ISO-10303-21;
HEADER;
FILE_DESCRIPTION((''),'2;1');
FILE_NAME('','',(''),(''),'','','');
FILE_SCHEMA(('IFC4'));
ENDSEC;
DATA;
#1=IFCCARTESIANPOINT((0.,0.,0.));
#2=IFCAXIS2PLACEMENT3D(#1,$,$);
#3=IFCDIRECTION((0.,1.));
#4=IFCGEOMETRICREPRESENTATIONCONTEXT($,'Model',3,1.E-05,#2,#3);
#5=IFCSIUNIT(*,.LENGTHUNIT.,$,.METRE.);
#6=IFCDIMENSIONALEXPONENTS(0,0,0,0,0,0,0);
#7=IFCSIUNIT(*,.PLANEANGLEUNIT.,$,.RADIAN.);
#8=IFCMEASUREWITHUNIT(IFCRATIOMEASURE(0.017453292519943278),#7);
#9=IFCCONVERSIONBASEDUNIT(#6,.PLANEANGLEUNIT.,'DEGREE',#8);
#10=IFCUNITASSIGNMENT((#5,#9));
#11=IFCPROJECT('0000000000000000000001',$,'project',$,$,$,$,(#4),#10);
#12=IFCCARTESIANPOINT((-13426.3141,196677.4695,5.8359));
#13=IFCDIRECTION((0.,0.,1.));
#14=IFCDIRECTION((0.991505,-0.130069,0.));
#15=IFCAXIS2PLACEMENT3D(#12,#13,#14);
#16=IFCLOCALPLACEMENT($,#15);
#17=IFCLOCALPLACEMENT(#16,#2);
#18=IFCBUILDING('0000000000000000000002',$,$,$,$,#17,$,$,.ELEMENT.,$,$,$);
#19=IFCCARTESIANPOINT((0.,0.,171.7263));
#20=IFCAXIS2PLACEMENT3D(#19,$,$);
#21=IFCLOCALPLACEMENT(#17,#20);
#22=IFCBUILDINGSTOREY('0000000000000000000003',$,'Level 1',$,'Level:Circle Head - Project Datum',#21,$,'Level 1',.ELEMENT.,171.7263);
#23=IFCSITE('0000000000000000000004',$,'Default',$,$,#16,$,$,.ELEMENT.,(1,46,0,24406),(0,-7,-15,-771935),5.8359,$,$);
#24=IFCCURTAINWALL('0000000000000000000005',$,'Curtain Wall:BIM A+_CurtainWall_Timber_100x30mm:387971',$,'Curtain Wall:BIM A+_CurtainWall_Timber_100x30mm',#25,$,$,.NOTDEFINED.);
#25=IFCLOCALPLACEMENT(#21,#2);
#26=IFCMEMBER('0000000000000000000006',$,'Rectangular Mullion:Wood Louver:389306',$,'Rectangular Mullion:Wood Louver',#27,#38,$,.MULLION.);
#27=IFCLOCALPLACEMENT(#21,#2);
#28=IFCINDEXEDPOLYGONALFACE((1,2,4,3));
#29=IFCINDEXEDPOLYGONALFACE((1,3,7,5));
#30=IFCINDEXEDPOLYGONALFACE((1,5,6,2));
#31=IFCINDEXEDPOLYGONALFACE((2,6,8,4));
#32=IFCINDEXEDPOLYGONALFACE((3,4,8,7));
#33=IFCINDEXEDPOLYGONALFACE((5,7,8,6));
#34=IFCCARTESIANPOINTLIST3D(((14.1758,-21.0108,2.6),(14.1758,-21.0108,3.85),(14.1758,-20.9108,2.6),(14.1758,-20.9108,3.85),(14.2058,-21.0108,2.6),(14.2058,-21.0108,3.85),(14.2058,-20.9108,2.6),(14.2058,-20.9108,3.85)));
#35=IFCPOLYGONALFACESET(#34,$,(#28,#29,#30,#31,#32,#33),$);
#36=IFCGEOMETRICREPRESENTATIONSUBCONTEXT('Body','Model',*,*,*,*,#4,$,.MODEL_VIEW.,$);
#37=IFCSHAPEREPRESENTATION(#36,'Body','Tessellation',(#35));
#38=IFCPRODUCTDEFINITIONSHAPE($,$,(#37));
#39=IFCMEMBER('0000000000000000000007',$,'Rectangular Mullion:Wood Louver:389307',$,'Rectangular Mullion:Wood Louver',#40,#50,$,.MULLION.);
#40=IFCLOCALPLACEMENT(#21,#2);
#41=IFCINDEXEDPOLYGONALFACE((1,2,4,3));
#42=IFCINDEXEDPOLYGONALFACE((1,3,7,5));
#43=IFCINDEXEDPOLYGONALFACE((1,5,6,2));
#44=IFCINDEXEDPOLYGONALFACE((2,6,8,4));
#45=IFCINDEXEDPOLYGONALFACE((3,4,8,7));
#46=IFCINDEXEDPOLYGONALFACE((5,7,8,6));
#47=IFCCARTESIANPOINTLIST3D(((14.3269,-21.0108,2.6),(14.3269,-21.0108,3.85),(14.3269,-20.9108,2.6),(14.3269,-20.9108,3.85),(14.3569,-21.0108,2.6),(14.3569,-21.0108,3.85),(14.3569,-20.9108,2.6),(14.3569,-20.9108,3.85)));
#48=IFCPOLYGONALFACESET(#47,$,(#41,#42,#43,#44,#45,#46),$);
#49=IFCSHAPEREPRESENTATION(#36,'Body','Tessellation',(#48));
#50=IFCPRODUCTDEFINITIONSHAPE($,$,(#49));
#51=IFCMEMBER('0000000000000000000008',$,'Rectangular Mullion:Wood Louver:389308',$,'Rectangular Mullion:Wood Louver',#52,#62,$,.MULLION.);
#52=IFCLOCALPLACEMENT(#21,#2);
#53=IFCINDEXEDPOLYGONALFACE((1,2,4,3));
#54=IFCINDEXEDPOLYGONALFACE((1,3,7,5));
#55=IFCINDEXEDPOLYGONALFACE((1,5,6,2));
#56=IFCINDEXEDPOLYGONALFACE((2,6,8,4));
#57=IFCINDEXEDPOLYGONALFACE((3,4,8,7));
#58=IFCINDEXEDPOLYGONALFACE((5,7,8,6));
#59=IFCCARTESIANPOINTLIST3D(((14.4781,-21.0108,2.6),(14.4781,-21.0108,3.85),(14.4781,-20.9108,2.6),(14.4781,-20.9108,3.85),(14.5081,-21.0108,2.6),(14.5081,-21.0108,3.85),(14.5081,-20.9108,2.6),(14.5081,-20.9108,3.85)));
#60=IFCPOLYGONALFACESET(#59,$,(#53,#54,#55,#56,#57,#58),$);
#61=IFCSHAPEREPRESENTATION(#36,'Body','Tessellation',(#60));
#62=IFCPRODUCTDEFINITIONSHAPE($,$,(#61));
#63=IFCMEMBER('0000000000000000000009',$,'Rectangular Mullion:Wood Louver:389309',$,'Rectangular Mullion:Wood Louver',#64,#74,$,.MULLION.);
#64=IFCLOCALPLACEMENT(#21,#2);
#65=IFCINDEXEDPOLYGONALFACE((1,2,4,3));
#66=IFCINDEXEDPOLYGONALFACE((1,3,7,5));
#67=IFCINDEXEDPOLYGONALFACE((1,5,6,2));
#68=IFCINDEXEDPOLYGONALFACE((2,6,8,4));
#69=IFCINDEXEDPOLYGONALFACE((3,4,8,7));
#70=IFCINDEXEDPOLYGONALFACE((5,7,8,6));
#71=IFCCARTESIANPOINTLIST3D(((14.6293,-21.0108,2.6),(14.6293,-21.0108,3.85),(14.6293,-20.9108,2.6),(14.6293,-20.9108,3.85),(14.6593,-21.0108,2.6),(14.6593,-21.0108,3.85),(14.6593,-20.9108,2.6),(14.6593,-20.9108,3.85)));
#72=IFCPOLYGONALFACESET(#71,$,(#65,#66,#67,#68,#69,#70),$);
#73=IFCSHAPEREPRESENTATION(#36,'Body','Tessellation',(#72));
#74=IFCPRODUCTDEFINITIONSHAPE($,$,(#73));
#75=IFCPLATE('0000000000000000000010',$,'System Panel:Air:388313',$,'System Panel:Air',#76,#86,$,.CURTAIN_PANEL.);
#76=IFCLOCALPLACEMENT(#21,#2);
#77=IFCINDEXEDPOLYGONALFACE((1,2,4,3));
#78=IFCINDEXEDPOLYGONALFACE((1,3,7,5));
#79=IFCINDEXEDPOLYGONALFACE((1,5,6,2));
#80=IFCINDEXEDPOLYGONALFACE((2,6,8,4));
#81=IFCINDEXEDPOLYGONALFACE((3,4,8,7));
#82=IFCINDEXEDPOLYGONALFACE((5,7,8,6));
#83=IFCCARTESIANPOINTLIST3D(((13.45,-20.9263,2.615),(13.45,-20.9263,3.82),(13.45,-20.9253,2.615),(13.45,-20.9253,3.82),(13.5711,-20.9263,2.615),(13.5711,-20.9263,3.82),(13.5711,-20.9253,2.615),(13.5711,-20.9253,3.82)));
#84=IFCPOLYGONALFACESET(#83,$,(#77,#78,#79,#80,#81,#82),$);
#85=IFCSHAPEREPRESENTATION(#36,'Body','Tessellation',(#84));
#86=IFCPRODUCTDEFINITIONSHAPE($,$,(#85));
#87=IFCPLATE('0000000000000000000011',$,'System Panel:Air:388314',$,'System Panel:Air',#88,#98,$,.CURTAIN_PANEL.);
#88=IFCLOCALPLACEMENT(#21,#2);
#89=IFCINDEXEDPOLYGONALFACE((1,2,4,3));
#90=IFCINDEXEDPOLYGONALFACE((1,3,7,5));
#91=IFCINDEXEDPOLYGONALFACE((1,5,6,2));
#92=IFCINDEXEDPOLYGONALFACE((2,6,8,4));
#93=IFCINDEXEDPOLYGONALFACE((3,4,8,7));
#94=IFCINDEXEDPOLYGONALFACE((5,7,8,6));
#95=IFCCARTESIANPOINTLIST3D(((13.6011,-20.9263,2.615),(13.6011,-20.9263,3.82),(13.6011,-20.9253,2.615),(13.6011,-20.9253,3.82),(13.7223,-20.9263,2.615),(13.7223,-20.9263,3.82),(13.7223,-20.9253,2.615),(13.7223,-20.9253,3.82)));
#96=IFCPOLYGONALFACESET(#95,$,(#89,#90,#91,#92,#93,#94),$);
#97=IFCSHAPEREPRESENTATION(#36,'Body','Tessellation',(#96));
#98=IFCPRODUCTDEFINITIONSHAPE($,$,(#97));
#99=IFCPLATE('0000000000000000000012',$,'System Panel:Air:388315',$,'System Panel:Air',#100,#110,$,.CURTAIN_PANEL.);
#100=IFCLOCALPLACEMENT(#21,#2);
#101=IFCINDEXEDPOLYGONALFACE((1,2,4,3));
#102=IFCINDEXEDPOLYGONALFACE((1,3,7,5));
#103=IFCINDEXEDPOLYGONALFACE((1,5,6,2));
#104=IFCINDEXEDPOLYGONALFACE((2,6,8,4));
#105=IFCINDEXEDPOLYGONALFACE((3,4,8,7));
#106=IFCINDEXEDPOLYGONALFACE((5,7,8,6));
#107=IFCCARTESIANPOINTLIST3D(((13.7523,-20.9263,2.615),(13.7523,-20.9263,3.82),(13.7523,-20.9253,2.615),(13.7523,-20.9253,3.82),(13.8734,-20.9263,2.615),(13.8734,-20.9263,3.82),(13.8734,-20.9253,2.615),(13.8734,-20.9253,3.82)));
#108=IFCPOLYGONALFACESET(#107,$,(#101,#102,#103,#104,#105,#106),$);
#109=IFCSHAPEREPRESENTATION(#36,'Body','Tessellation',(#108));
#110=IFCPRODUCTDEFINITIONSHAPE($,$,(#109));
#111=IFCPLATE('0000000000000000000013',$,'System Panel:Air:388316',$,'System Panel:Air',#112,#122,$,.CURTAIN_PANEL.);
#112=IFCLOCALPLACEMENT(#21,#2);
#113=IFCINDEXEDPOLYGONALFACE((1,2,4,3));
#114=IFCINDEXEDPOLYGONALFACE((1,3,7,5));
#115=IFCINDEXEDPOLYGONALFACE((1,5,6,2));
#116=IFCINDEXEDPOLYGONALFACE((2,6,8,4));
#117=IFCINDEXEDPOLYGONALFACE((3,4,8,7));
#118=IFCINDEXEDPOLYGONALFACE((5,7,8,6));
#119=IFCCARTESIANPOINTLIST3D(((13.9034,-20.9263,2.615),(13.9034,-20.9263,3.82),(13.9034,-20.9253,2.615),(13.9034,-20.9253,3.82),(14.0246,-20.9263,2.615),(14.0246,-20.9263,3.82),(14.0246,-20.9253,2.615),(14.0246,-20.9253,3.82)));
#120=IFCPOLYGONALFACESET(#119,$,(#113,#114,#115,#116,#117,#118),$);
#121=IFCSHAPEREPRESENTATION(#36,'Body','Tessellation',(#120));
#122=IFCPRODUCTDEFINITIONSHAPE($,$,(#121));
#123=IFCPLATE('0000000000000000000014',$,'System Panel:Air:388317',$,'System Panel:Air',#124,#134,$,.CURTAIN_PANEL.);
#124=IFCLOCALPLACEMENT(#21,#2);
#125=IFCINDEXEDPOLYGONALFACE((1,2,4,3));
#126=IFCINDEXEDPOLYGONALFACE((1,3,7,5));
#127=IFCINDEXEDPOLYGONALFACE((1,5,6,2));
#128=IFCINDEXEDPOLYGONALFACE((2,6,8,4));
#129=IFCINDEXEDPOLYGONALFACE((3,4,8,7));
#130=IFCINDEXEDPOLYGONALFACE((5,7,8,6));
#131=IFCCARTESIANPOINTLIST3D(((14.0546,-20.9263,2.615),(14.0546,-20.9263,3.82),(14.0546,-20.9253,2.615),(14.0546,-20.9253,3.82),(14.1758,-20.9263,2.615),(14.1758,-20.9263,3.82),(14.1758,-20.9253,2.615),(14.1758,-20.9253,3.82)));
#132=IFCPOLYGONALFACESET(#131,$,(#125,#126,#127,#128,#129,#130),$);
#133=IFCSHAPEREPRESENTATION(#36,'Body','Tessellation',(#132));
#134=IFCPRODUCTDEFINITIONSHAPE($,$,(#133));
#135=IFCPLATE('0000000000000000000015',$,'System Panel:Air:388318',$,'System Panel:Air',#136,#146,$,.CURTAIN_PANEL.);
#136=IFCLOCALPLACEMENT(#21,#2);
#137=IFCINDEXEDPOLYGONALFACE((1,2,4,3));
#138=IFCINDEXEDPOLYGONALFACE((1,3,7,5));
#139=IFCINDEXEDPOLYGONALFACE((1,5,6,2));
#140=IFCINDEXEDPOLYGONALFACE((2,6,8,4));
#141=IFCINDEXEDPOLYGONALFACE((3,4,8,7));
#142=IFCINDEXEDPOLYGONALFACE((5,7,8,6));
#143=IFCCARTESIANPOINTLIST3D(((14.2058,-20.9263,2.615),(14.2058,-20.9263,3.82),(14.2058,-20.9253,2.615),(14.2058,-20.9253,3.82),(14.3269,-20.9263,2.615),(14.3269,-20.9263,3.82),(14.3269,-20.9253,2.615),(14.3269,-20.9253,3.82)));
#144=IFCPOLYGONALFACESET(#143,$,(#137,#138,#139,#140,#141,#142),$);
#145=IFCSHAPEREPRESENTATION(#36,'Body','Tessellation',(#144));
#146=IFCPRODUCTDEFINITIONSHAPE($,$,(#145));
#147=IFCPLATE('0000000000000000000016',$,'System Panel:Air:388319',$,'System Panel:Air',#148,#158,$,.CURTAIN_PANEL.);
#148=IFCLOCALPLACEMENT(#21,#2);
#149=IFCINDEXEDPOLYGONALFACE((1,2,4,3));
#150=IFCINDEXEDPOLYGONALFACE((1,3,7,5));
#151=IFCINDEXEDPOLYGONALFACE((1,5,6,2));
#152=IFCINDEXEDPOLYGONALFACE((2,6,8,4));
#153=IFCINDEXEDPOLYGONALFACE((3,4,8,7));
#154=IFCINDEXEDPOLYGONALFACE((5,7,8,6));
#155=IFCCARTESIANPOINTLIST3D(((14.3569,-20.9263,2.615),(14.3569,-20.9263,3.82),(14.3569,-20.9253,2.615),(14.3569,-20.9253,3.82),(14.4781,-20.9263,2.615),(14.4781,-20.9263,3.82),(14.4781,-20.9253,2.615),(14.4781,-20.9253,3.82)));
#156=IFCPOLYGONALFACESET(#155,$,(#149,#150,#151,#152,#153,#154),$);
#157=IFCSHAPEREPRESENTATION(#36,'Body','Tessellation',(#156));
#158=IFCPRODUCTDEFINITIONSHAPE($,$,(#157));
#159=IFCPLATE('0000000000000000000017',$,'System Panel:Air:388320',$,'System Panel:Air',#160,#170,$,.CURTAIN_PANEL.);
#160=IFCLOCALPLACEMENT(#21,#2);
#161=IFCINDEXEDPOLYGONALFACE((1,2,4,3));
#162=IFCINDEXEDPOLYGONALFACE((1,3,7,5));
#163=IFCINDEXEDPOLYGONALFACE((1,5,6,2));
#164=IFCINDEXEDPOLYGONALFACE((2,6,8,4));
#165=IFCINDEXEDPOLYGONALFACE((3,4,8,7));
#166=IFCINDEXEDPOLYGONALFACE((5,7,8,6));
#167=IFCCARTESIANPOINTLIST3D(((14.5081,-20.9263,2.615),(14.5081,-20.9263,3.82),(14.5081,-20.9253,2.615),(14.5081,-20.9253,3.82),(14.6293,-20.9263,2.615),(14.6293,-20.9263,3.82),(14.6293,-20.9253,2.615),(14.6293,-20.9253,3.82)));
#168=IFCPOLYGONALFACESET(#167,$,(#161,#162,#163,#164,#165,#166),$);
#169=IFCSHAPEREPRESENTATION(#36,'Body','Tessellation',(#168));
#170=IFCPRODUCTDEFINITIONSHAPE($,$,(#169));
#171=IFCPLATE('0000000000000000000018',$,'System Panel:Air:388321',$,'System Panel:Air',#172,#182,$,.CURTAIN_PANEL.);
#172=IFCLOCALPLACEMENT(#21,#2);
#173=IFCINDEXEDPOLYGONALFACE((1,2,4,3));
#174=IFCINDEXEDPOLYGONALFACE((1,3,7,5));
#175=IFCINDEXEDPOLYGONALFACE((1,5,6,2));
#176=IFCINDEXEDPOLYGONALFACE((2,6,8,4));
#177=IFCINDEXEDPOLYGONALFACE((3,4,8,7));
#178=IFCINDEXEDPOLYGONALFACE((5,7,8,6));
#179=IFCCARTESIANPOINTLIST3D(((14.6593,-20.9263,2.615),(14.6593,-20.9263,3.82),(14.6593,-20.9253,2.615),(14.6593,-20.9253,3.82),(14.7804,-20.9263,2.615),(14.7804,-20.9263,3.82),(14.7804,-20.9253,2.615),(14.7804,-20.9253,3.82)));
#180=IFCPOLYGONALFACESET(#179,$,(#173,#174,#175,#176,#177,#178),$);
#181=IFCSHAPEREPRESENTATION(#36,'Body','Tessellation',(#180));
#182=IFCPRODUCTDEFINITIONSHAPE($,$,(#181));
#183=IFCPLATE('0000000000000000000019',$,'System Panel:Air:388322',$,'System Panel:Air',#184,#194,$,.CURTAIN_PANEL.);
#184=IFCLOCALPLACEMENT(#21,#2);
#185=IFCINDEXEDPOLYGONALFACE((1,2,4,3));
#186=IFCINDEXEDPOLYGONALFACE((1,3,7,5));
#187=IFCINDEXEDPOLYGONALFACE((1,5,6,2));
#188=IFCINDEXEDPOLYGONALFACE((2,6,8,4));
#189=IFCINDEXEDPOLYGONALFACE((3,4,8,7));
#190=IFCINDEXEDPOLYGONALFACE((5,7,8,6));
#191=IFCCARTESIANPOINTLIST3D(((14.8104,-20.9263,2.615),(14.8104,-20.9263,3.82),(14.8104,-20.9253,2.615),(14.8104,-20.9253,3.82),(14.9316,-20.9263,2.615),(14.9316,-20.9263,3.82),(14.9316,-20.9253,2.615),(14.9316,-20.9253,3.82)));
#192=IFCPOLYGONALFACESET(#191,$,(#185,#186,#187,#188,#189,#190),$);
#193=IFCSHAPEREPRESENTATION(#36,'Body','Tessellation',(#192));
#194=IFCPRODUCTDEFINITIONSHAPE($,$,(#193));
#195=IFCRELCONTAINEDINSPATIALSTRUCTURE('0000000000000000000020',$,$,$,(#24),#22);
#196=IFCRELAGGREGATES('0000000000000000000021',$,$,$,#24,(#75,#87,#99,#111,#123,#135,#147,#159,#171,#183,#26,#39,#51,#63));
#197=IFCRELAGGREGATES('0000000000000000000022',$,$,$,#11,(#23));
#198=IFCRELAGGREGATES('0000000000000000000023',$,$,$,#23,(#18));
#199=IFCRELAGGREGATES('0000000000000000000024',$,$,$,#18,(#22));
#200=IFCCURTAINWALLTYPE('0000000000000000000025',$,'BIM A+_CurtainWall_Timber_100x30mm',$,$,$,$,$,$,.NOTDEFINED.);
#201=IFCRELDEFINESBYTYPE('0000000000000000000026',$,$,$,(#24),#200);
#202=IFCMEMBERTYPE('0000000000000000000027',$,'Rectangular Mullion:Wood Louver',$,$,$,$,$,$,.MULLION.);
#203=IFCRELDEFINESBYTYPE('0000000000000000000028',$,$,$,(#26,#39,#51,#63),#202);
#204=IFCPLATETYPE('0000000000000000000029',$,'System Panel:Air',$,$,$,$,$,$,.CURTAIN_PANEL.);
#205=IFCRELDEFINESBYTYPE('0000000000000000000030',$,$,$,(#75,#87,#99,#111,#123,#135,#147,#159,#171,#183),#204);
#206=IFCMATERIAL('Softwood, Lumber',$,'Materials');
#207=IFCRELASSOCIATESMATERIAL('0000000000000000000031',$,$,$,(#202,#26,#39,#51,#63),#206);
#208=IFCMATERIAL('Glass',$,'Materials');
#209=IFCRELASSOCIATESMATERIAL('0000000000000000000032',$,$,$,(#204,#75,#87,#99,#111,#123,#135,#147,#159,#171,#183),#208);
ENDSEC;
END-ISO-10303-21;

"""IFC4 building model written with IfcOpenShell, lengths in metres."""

from ifc_helpers import new_model, entity, si_unit, converted_unit, direction, frame, origin, place, context, subcontext, project, spatial, indexed_curve, outline, extrude, source, transform, mapped, material, type_object, type_shapes, element, aggregate, save


model = new_model("IFC4")

# Units and contexts
model_context = context("Model", 3, precision=1e-05, world=origin(), true_north=direction((0.0, 1.0)))
body_context = subcontext(model_context, "Body", "Model", "MODEL_VIEW")
ifc_project = project(units=[si_unit("LENGTHUNIT", "METRE"), converted_unit("PLANEANGLEUNIT", "DEGREE", entity("IfcRatioMeasure", 0.017453292519943278), si_unit("PLANEANGLEUNIT", "RADIAN"), dimensions=[0, 0, 0, 0, 0, 0, 0])], contexts=[model_context])

# Site, building, storey
site_placement = place(None, frame((-13426.3141, 196677.4695, 5.8359), z_axis=(0.0, 0.0, 1.0), x_axis=(0.991505, -0.130069, 0.0)))
site = spatial("IfcSite", under=ifc_project, at=site_placement, Name="Default", CompositionType="ELEMENT", RefLatitude=(1, 46, 0, 24406), RefLongitude=(0, -7, -15, -771935), RefElevation=5.8359)
building_placement = place(site_placement, origin())
building = spatial("IfcBuilding", under=site, at=building_placement, CompositionType="ELEMENT")
storey_placement = place(building_placement, frame((0.0, 0.0, 171.7263)))
storey = spatial("IfcBuildingStorey", under=building, at=storey_placement, Name="Level 1", ObjectType="Level:Circle Head - Project Datum", LongName="Level 1", CompositionType="ELEMENT", Elevation=171.7263)

# Curtain wall, members, plates
curtain_wall_type = type_object("IfcCurtainWallType", Name="BIM A+_CurtainWall_Timber_100x30mm", PredefinedType="NOTDEFINED")
curtain_wall_placement = place(storey_placement, frame((0.0, 0.0, -171.7263)))
curtain_wall = element("IfcCurtainWall", 1, at=curtain_wall_placement, inside=storey, type_object=curtain_wall_type, Name="Curtain Wall:BIM A+_CurtainWall_Timber_100x30mm:387971", ObjectType="Curtain Wall:BIM A+_CurtainWall_Timber_100x30mm", PredefinedType="NOTDEFINED")
ifc_material_1 = material(Name="Softwood, Lumber", Category="Materials")
member_type_1 = type_object("IfcMemberType", Name="Rectangular Mullion:Wood Louver", PredefinedType="MULLION", material=ifc_material_1)
shared_shape_1 = source(origin(), body_context, "Body", "SweptSolid", [
    extrude(outline(indexed_curve([(-0.05, -0.015), (0.05, -0.015), (0.05, 0.015), (-0.05, 0.015), (-0.05, -0.015)], self_intersect=False)), frame((0.0, 0.035, -1.25), z_axis=(0.0, 0.0, 1.0), x_axis=(0.0, -1.0, 0.0)), (0.0, 0.0, 1.0), 1.25),
])
type_shapes(member_type_1, [shared_shape_1])
member_1_placement = place(curtain_wall_placement, frame((14.1908, -20.9258, 174.3263), z_axis=(0.0, 0.0, -1.0), x_axis=(1.0, 0.0, 0.0)))
member_1 = element("IfcMember", 2, at=member_1_placement, type_object=member_type_1, material=ifc_material_1, Name="Rectangular Mullion:Wood Louver:389306", ObjectType="Rectangular Mullion:Wood Louver", PredefinedType="MULLION", context=body_context, shape_type="MappedRepresentation", body=[
    mapped(shared_shape_1, transform((0.0, 0.0, 0.0), scale=1.0)),
])
member_2_placement = place(curtain_wall_placement, frame((14.3419, -20.9258, 174.3263), z_axis=(0.0, 0.0, -1.0), x_axis=(1.0, 0.0, 0.0)))
member_2 = element("IfcMember", 3, at=member_2_placement, type_object=member_type_1, material=ifc_material_1, Name="Rectangular Mullion:Wood Louver:389307", ObjectType="Rectangular Mullion:Wood Louver", PredefinedType="MULLION", context=body_context, shape_type="MappedRepresentation", body=[
    mapped(shared_shape_1, transform((0.0, 0.0, 0.0), scale=1.0)),
])
member_3_placement = place(curtain_wall_placement, frame((14.4931, -20.9258, 174.3263), z_axis=(0.0, 0.0, -1.0), x_axis=(1.0, 0.0, 0.0)))
member_3 = element("IfcMember", 4, at=member_3_placement, type_object=member_type_1, material=ifc_material_1, Name="Rectangular Mullion:Wood Louver:389308", ObjectType="Rectangular Mullion:Wood Louver", PredefinedType="MULLION", context=body_context, shape_type="MappedRepresentation", body=[
    mapped(shared_shape_1, transform((0.0, 0.0, 0.0), scale=1.0)),
])
member_4_placement = place(curtain_wall_placement, frame((14.6443, -20.9258, 174.3263), z_axis=(0.0, 0.0, -1.0), x_axis=(1.0, 0.0, 0.0)))
member_4 = element("IfcMember", 5, at=member_4_placement, type_object=member_type_1, material=ifc_material_1, Name="Rectangular Mullion:Wood Louver:389309", ObjectType="Rectangular Mullion:Wood Louver", PredefinedType="MULLION", context=body_context, shape_type="MappedRepresentation", body=[
    mapped(shared_shape_1, transform((0.0, 0.0, 0.0), scale=1.0)),
])
ifc_material_2 = material(Name="Glass", Category="Materials")
plate_type = type_object("IfcPlateType", Name="System Panel:Air", PredefinedType="CURTAIN_PANEL", material=ifc_material_2)
shared_shape_2 = source(origin(), body_context, "Body", "SweptSolid", [
    extrude(outline(indexed_curve([(-0.0005, -0.0606), (0.0005, -0.0606), (0.0005, 0.0606), (-0.0005, 0.0606), (-0.0005, -0.0606)], self_intersect=False)), frame((0.0, 0.0, 0.0), z_axis=(0.0, 0.0, 1.0), x_axis=(0.0, 1.0, 0.0)), (0.0, 0.0, 1.0), 1.205),
])
type_shapes(plate_type, [shared_shape_2])
plate_1_placement = place(curtain_wall_placement, frame((13.5105, -20.9258, 174.3413)))
plate_1 = element("IfcPlate", 6, at=plate_1_placement, type_object=plate_type, material=ifc_material_2, Name="System Panel:Air:388313", ObjectType="System Panel:Air", PredefinedType="CURTAIN_PANEL", context=body_context, shape_type="MappedRepresentation", body=[
    mapped(shared_shape_2, transform((0.0, 0.0, 0.0), scale=1.0)),
])
plate_2_placement = place(curtain_wall_placement, frame((13.6617, -20.9258, 174.3413)))
plate_2 = element("IfcPlate", 7, at=plate_2_placement, type_object=plate_type, material=ifc_material_2, Name="System Panel:Air:388314", ObjectType="System Panel:Air", PredefinedType="CURTAIN_PANEL", context=body_context, shape_type="MappedRepresentation", body=[
    mapped(shared_shape_2, transform((0.0, 0.0, 0.0), scale=1.0)),
])
plate_3_placement = place(curtain_wall_placement, frame((13.8129, -20.9258, 174.3413)))
plate_3 = element("IfcPlate", 8, at=plate_3_placement, type_object=plate_type, material=ifc_material_2, Name="System Panel:Air:388315", ObjectType="System Panel:Air", PredefinedType="CURTAIN_PANEL", context=body_context, shape_type="MappedRepresentation", body=[
    mapped(shared_shape_2, transform((0.0, 0.0, 0.0), scale=1.0)),
])
plate_4_placement = place(curtain_wall_placement, frame((13.964, -20.9258, 174.3413)))
plate_4 = element("IfcPlate", 9, at=plate_4_placement, type_object=plate_type, material=ifc_material_2, Name="System Panel:Air:388316", ObjectType="System Panel:Air", PredefinedType="CURTAIN_PANEL", context=body_context, shape_type="MappedRepresentation", body=[
    mapped(shared_shape_2, transform((0.0, 0.0, 0.0), scale=1.0)),
])
plate_5_placement = place(curtain_wall_placement, frame((14.1152, -20.9258, 174.3413)))
plate_5 = element("IfcPlate", 10, at=plate_5_placement, type_object=plate_type, material=ifc_material_2, Name="System Panel:Air:388317", ObjectType="System Panel:Air", PredefinedType="CURTAIN_PANEL", context=body_context, shape_type="MappedRepresentation", body=[
    mapped(shared_shape_2, transform((0.0, 0.0, 0.0), scale=1.0)),
])
plate_6_placement = place(curtain_wall_placement, frame((14.2664, -20.9258, 174.3413)))
plate_6 = element("IfcPlate", 11, at=plate_6_placement, type_object=plate_type, material=ifc_material_2, Name="System Panel:Air:388318", ObjectType="System Panel:Air", PredefinedType="CURTAIN_PANEL", context=body_context, shape_type="MappedRepresentation", body=[
    mapped(shared_shape_2, transform((0.0, 0.0, 0.0), scale=1.0)),
])
plate_7_placement = place(curtain_wall_placement, frame((14.4175, -20.9258, 174.3413)))
plate_7 = element("IfcPlate", 12, at=plate_7_placement, type_object=plate_type, material=ifc_material_2, Name="System Panel:Air:388319", ObjectType="System Panel:Air", PredefinedType="CURTAIN_PANEL", context=body_context, shape_type="MappedRepresentation", body=[
    mapped(shared_shape_2, transform((0.0, 0.0, 0.0), scale=1.0)),
])
plate_8_placement = place(curtain_wall_placement, frame((14.5687, -20.9258, 174.3413)))
plate_8 = element("IfcPlate", 13, at=plate_8_placement, type_object=plate_type, material=ifc_material_2, Name="System Panel:Air:388320", ObjectType="System Panel:Air", PredefinedType="CURTAIN_PANEL", context=body_context, shape_type="MappedRepresentation", body=[
    mapped(shared_shape_2, transform((0.0, 0.0, 0.0), scale=1.0)),
])
plate_9_placement = place(curtain_wall_placement, frame((14.7198, -20.9258, 174.3413)))
plate_9 = element("IfcPlate", 14, at=plate_9_placement, type_object=plate_type, material=ifc_material_2, Name="System Panel:Air:388321", ObjectType="System Panel:Air", PredefinedType="CURTAIN_PANEL", context=body_context, shape_type="MappedRepresentation", body=[
    mapped(shared_shape_2, transform((0.0, 0.0, 0.0), scale=1.0)),
])
plate_10_placement = place(curtain_wall_placement, frame((14.871, -20.9258, 174.3413)))
plate_10 = element("IfcPlate", 15, at=plate_10_placement, type_object=plate_type, material=ifc_material_2, Name="System Panel:Air:388322", ObjectType="System Panel:Air", PredefinedType="CURTAIN_PANEL", context=body_context, shape_type="MappedRepresentation", body=[
    mapped(shared_shape_2, transform((0.0, 0.0, 0.0), scale=1.0)),
])
aggregate(curtain_wall, [plate_1, plate_2, plate_3, plate_4, plate_5, plate_6, plate_7, plate_8, plate_9, plate_10, member_1, member_2, member_3, member_4])

save(model, "model.ifc")
